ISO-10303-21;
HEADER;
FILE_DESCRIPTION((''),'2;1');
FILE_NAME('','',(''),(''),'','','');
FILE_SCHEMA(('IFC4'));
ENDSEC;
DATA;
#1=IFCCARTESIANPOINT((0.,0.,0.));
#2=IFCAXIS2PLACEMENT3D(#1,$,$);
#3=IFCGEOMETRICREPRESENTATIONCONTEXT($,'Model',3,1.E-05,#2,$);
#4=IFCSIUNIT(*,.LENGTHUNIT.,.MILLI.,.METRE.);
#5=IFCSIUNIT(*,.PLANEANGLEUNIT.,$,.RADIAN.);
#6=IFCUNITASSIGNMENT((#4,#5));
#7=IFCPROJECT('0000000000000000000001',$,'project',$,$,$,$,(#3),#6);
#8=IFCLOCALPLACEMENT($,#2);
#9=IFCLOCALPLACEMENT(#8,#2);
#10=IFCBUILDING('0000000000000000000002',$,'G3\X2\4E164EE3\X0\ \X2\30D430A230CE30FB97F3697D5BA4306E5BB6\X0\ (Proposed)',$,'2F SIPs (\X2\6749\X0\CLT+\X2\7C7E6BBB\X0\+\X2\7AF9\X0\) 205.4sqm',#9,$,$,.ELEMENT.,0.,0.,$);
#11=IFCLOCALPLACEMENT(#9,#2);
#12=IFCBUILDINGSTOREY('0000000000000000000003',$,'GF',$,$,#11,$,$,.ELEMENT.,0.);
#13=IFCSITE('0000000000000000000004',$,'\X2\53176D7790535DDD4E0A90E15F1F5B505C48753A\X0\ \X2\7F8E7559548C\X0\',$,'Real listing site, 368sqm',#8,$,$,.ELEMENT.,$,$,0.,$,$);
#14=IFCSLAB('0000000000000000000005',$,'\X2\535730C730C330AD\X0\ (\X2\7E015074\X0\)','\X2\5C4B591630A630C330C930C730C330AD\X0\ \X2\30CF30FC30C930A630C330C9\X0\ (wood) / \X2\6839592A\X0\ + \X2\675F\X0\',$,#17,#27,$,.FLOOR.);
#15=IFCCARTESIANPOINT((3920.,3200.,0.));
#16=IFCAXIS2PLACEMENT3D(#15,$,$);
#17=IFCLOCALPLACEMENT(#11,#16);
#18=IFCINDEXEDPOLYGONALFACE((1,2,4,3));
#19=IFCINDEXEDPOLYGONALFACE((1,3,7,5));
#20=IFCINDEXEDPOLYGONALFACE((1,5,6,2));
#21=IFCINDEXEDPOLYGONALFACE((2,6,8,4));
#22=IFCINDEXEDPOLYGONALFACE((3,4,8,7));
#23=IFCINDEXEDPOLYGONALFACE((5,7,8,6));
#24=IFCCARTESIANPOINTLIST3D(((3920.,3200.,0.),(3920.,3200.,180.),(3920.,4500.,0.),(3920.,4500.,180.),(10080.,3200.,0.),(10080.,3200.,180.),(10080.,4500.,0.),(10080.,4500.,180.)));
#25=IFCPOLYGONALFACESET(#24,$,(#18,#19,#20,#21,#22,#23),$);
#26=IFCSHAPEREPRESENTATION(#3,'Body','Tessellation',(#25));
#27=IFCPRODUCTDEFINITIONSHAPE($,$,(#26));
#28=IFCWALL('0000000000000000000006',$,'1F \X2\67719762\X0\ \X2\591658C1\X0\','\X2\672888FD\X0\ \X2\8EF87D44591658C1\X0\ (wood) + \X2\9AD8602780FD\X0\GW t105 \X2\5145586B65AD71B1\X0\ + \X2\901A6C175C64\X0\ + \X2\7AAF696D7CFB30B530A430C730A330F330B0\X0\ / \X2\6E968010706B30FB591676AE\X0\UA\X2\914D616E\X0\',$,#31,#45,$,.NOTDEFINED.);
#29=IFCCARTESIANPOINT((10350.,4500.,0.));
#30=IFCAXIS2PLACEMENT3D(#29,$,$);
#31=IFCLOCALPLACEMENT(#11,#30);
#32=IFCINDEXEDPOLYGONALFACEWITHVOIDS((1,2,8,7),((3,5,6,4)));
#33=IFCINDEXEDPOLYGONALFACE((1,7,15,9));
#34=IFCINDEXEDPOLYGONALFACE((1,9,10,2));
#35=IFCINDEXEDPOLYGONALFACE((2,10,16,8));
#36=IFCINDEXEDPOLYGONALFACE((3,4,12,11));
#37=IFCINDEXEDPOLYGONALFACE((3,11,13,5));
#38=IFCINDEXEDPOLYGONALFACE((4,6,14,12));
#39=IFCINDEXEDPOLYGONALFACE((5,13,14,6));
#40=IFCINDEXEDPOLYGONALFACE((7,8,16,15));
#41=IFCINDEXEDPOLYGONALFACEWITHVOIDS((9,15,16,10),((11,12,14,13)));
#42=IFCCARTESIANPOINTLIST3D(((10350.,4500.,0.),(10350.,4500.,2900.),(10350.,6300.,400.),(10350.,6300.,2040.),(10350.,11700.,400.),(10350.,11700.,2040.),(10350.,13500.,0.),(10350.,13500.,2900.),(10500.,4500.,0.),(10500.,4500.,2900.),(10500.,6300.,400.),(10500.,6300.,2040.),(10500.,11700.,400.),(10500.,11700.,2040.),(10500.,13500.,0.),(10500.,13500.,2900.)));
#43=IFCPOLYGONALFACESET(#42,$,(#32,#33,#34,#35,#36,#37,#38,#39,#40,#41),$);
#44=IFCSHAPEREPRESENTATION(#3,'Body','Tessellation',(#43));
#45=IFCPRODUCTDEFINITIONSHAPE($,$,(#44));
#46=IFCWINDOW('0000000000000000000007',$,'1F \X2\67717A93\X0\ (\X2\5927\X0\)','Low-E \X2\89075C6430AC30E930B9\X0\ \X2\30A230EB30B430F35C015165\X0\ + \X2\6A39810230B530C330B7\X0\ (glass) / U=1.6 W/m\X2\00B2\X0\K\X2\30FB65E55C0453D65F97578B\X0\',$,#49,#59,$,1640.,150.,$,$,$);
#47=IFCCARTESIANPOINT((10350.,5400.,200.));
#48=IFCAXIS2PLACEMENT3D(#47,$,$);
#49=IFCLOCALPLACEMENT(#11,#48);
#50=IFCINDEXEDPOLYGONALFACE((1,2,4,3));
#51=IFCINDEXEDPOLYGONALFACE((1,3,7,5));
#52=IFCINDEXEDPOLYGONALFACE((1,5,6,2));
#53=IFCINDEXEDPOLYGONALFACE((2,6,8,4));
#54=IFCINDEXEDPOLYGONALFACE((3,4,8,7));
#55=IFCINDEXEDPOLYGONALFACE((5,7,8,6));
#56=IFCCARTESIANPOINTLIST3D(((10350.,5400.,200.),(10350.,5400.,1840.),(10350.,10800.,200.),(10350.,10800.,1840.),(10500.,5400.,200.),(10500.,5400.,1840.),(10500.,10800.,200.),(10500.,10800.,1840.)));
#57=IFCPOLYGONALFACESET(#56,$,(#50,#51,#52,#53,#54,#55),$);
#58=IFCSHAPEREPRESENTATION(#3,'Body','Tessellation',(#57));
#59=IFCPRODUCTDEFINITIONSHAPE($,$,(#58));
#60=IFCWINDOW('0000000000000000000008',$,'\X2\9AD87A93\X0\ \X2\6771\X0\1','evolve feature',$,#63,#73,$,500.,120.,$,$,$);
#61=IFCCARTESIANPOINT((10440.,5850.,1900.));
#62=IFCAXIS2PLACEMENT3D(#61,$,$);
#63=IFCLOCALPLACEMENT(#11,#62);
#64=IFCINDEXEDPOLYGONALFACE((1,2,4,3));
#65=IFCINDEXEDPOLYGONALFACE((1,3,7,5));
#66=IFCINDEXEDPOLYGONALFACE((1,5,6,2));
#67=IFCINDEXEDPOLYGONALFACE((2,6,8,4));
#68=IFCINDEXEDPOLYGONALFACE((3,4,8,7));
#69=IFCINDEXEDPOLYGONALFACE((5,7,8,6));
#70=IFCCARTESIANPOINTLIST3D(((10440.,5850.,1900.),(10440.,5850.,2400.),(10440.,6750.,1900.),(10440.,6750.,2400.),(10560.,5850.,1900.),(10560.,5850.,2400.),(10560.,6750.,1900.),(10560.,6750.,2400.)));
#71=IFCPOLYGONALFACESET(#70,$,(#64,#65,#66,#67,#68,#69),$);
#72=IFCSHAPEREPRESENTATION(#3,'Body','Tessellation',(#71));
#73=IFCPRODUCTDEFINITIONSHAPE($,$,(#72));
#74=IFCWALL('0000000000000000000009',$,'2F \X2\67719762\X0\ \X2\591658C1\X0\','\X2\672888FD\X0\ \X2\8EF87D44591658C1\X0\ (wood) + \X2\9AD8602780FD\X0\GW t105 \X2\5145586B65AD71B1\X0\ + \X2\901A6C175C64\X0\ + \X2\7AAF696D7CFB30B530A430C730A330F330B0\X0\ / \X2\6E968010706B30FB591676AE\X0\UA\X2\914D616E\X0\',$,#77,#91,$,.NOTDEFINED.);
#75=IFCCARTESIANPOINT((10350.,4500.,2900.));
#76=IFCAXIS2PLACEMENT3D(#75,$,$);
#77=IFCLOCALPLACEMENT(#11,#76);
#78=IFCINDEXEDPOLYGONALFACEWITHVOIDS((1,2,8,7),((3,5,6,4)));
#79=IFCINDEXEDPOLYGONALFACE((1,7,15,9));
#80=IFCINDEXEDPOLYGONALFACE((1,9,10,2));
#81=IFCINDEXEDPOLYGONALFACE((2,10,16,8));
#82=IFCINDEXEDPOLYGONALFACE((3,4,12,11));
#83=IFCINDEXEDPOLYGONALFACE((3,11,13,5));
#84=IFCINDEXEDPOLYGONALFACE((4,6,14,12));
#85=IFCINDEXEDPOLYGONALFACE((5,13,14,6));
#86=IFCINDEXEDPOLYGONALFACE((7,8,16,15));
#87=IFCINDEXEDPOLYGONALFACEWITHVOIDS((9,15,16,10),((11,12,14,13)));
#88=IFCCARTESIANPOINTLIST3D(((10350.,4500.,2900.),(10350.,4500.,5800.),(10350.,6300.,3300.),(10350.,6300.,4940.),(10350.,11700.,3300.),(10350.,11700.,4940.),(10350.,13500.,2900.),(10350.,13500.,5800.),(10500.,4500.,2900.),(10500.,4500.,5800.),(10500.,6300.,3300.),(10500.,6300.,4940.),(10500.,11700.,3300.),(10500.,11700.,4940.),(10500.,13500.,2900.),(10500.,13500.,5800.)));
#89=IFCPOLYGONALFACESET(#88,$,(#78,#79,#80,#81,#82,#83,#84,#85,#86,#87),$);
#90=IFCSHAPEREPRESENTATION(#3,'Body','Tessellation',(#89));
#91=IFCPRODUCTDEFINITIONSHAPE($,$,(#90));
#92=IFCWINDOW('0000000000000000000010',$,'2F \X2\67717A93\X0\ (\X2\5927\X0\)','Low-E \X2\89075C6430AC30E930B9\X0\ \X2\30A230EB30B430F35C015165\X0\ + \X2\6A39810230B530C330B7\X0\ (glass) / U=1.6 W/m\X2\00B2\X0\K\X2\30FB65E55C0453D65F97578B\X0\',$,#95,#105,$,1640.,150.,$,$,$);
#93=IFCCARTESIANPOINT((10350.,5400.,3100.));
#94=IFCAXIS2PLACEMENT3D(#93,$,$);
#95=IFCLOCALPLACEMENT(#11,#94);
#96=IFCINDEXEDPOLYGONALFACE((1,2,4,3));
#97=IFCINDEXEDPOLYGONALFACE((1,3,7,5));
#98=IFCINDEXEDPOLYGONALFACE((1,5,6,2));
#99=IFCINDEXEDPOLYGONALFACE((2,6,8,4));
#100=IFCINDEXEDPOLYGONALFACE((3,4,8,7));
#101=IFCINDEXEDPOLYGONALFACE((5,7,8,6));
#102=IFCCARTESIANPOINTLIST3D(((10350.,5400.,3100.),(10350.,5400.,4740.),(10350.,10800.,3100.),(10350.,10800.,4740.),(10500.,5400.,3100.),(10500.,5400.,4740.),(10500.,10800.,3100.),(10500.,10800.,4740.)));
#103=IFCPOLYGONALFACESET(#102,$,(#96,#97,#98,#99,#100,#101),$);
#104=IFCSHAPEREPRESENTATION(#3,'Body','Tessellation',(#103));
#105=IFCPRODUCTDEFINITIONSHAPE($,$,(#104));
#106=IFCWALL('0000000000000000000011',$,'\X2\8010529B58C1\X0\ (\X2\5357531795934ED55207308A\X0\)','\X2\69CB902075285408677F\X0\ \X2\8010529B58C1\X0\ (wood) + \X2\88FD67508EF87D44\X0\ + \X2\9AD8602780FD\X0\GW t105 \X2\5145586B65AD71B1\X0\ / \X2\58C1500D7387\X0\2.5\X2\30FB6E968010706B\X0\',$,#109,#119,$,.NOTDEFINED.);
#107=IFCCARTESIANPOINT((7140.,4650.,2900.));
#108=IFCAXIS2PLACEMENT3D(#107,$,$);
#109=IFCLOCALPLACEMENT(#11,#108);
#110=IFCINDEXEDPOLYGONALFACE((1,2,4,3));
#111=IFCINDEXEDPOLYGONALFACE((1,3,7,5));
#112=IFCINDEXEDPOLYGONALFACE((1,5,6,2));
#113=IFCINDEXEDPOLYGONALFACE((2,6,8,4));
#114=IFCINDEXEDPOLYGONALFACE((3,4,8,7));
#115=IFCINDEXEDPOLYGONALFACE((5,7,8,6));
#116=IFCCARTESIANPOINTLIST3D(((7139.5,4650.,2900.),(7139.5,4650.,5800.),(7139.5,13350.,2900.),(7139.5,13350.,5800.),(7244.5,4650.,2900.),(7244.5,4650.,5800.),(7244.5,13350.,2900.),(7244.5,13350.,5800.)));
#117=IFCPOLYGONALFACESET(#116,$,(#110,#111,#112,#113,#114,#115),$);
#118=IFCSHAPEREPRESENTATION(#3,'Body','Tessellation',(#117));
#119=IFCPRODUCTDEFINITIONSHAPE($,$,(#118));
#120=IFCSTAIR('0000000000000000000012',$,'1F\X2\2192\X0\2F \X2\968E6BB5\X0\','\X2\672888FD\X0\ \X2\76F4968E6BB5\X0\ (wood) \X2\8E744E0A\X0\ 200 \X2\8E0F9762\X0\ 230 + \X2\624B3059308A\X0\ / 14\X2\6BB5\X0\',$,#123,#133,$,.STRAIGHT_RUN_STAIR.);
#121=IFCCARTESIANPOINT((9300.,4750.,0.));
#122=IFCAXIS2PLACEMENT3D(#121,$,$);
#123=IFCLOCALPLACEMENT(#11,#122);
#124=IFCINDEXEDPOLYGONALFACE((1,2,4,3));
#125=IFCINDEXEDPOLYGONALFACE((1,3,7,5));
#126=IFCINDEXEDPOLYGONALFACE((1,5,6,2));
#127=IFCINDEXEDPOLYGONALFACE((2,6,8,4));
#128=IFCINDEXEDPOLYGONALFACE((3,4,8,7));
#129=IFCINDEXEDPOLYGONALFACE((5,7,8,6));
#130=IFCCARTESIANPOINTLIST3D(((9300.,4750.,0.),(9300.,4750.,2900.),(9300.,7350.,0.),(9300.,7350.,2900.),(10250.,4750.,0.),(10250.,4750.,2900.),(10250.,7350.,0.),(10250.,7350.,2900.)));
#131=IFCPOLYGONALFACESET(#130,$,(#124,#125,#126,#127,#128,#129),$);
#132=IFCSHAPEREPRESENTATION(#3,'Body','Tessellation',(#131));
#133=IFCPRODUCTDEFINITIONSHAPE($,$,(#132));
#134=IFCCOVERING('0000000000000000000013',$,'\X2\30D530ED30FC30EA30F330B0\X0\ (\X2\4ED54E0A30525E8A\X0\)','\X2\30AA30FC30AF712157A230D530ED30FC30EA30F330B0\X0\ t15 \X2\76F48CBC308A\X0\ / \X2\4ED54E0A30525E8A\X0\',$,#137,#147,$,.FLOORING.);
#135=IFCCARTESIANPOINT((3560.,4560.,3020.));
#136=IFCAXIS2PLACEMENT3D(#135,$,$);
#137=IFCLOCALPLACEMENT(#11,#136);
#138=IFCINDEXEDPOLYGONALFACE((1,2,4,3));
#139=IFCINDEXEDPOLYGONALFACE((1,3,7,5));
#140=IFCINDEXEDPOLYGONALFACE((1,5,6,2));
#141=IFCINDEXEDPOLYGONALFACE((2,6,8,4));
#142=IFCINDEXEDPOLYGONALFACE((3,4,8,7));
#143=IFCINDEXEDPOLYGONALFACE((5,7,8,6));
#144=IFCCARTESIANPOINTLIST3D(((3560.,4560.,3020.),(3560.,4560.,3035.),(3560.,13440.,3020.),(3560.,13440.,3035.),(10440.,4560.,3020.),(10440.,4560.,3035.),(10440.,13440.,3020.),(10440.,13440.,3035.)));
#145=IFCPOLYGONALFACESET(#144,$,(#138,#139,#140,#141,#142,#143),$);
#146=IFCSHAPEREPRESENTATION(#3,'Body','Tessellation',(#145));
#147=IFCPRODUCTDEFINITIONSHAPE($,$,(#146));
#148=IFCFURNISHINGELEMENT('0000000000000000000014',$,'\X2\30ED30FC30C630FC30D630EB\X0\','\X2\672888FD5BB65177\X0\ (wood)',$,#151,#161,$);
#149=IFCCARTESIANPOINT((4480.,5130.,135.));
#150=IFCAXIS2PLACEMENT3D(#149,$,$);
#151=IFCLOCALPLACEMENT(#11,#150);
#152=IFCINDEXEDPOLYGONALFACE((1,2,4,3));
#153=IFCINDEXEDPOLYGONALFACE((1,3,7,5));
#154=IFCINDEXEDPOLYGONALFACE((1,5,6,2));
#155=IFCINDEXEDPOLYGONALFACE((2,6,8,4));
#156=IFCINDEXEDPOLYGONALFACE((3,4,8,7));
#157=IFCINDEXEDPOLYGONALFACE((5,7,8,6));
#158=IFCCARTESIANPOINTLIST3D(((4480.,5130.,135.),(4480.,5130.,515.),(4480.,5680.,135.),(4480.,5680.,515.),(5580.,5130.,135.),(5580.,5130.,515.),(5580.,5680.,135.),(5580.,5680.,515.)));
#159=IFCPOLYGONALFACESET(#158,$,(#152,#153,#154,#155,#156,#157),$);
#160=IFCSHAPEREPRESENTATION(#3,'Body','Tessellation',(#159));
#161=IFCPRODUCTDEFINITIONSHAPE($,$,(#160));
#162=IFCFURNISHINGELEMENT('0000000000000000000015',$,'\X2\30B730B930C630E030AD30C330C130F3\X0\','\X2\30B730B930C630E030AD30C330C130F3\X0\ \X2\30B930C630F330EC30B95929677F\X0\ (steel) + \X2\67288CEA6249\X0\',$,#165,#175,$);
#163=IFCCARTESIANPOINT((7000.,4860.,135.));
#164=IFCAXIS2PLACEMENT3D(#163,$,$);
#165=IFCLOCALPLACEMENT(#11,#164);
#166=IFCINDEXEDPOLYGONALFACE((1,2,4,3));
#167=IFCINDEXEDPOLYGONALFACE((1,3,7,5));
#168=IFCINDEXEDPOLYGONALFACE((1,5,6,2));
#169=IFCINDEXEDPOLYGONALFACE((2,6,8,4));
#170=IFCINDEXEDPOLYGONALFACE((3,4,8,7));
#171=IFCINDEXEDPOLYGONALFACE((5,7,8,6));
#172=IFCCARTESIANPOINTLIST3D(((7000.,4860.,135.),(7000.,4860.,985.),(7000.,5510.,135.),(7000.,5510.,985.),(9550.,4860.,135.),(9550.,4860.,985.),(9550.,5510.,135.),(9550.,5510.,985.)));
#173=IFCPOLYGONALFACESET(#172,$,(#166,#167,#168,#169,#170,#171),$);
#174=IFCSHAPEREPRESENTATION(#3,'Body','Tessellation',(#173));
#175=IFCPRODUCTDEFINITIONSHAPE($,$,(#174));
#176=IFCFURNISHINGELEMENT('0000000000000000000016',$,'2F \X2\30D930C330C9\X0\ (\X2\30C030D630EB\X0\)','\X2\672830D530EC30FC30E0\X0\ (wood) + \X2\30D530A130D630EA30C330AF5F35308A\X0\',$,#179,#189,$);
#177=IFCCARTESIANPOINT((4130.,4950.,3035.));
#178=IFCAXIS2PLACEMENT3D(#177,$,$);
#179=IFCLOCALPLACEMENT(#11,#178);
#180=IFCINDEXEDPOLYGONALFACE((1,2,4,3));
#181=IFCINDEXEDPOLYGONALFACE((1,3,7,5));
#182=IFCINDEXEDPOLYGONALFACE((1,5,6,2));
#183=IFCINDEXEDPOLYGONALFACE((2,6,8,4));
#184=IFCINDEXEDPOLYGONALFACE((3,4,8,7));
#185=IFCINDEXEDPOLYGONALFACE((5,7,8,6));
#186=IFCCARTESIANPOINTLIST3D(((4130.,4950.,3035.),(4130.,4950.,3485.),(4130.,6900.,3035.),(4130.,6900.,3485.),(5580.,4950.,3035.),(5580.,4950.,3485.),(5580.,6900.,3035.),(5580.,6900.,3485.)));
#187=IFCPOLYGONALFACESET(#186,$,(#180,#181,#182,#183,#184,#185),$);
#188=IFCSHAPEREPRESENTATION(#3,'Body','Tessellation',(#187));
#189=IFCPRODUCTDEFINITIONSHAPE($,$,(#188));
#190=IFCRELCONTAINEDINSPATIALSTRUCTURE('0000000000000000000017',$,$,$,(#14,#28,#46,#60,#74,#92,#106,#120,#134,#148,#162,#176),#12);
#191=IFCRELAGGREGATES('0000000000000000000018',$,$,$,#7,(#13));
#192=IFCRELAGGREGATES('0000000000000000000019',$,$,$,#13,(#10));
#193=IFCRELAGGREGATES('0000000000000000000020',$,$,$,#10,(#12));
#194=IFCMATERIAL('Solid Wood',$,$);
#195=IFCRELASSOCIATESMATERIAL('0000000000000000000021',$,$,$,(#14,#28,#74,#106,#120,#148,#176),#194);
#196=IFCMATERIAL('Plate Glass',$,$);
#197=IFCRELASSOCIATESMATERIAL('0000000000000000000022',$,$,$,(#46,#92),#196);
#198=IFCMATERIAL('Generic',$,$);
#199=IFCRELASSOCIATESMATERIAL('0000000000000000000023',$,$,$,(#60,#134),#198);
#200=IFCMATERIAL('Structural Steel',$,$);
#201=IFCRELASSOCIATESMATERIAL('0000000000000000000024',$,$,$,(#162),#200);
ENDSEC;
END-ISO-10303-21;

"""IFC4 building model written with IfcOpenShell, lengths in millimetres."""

from ifc_helpers import new_model, si_unit, frame, frame_2d, origin, place, context, project, spatial, rectangle, extrude, material, element, fill, save


model = new_model("IFC4")

# Units and contexts
model_context = context("Model", 3, precision=1e-05, world=origin())
ifc_project = project(units=[si_unit("LENGTHUNIT", "METRE", prefix="MILLI"), si_unit("PLANEANGLEUNIT", "RADIAN")], contexts=[model_context])

# Site, building, storey
site_placement = place(None, origin())
site = spatial("IfcSite", under=ifc_project, at=site_placement, Name="北海道川上郡弟子屈町 美留和", ObjectType="Real listing site, 368sqm", CompositionType="ELEMENT", RefElevation=0.0)
building_placement = place(site_placement, origin())
building = spatial("IfcBuilding", under=site, at=building_placement, Name="G3世代 ピアノ・音楽室の家 (Proposed)", ObjectType="2F SIPs (杉CLT+籾殻+竹) 205.4sqm", CompositionType="ELEMENT", ElevationOfRefHeight=0.0, ElevationOfTerrain=0.0)
storey_placement = place(building_placement, origin())
storey = spatial("IfcBuildingStorey", under=building, at=storey_placement, Name="GF", CompositionType="ELEMENT", Elevation=0.0)

# Slab
ifc_material_1 = material(Name="Solid Wood")
slab_placement = place(storey_placement, frame((3920.0, 3200.0, 0.0)))
element("IfcSlab", 1, at=slab_placement, inside=storey, material=ifc_material_1, Name="南デッキ (縁側)", Description="屋外ウッドデッキ ハードウッド (wood) / 根太 + 束", PredefinedType="FLOOR", context=model_context, shape_type="SweptSolid", body=[
    extrude(rectangle(XDim=6160.0, YDim=1300.0, at=frame_2d((3080.0, 650.0))), frame((3920.0, 3200.0, 0.0)), (0.0, 0.0, 1.0), 180.0),
])

# Wall, openings, windows
wall_1_placement = place(storey_placement, frame((10350.0, 4500.0, 0.0)))
wall_1 = element("IfcWall", 2, at=wall_1_placement, inside=storey, material=ifc_material_1, Name="1F 東面 外壁", Description="木製 軸組外壁 (wood) + 高性能GW t105 充填断熱 + 通気層 + 窯業系サイディング / 準耐火・外皮UA配慮", PredefinedType="NOTDEFINED", context=model_context, shape_type="SweptSolid", body=[
    extrude(rectangle(XDim=150.0, YDim=9000.0, at=frame_2d((75.0, 4500.0))), frame((10350.0, 4500.0, 0.0)), (0.0, 0.0, 1.0), 2900.0),
])
opening_1_placement = place(storey_placement, frame((10350.0, 5400.0, 200.0)))
opening_1 = element("IfcOpeningElement", 3, at=opening_1_placement, cuts=wall_1, PredefinedType="NOTDEFINED", context=model_context, shape_type="SweptSolid", body=[
    extrude(rectangle(XDim=150.0, YDim=5400.0, at=frame_2d((75.0, 2700.0))), frame((10350.0, 5400.0, 200.0)), (0.0, 0.0, 1.0), 1640.0),
])
opening_2_placement = place(storey_placement, frame((10440.0, 5850.0, 1900.0)))
opening_2 = element("IfcOpeningElement", 4, at=opening_2_placement, cuts=wall_1, PredefinedType="NOTDEFINED", context=model_context, shape_type="SweptSolid", body=[
    extrude(rectangle(XDim=120.0, YDim=900.0, at=frame_2d((60.0, 450.0))), frame((10440.0, 5850.0, 1900.0)), (0.0, 0.0, 1.0), 500.0),
])
ifc_material_2 = material(Name="Plate Glass")
window_1_placement = place(storey_placement, frame((10350.0, 5400.0, 200.0)))
window_1 = element("IfcWindow", 5, at=window_1_placement, inside=storey, material=ifc_material_2, Name="1F 東窓 (大)", Description="Low-E 複層ガラス アルゴン封入 + 樹脂サッシ (glass) / U=1.6 W/m²K・日射取得型", OverallHeight=1640.0, OverallWidth=150.0, context=model_context, shape_type="SweptSolid", body=[
    extrude(rectangle(XDim=150.0, YDim=5400.0, at=frame_2d((75.0, 2700.0))), frame((10350.0, 5400.0, 200.0)), (0.0, 0.0, 1.0), 1640.0),
])
fill(opening_1, window_1)
ifc_material_3 = material(Name="Generic")
window_2_placement = place(storey_placement, frame((10440.0, 5850.0, 1900.0)))
window_2 = element("IfcWindow", 6, at=window_2_placement, inside=storey, material=ifc_material_3, Name="高窓 東1", Description="evolve feature", OverallHeight=500.0, OverallWidth=120.0, context=model_context, shape_type="SweptSolid", body=[
    extrude(rectangle(XDim=120.0, YDim=900.0, at=frame_2d((60.0, 450.0))), frame((10440.0, 5850.0, 1900.0)), (0.0, 0.0, 1.0), 500.0),
])
fill(opening_2, window_2)

# Wall, opening, window
wall_2_placement = place(storey_placement, frame((10350.0, 4500.0, 2900.0)))
wall_2 = element("IfcWall", 7, at=wall_2_placement, inside=storey, material=ifc_material_1, Name="2F 東面 外壁", Description="木製 軸組外壁 (wood) + 高性能GW t105 充填断熱 + 通気層 + 窯業系サイディング / 準耐火・外皮UA配慮", PredefinedType="NOTDEFINED", context=model_context, shape_type="SweptSolid", body=[
    extrude(rectangle(XDim=150.0, YDim=9000.0, at=frame_2d((75.0, 4500.0))), frame((10350.0, 4500.0, 2900.0)), (0.0, 0.0, 1.0), 2900.0),
])
opening_3_placement = place(storey_placement, frame((10350.0, 5400.0, 3100.0)))
opening_3 = element("IfcOpeningElement", 8, at=opening_3_placement, cuts=wall_2, PredefinedType="NOTDEFINED", context=model_context, shape_type="SweptSolid", body=[
    extrude(rectangle(XDim=150.0, YDim=5400.0, at=frame_2d((75.0, 2700.0))), frame((10350.0, 5400.0, 3100.0)), (0.0, 0.0, 1.0), 1640.0),
])
window_3_placement = place(storey_placement, frame((10350.0, 5400.0, 3100.0)))
window_3 = element("IfcWindow", 9, at=window_3_placement, inside=storey, material=ifc_material_2, Name="2F 東窓 (大)", Description="Low-E 複層ガラス アルゴン封入 + 樹脂サッシ (glass) / U=1.6 W/m²K・日射取得型", OverallHeight=1640.0, OverallWidth=150.0, context=model_context, shape_type="SweptSolid", body=[
    extrude(rectangle(XDim=150.0, YDim=5400.0, at=frame_2d((75.0, 2700.0))), frame((10350.0, 5400.0, 3100.0)), (0.0, 0.0, 1.0), 1640.0),
])
fill(opening_3, window_3)

# Wall
wall_3_placement = place(storey_placement, frame((7140.0, 4650.0, 2900.0)))
element("IfcWall", 10, at=wall_3_placement, inside=storey, material=ifc_material_1, Name="耐力壁 (南北間仕切り)", Description="構造用合板 耐力壁 (wood) + 製材軸組 + 高性能GW t105 充填断熱 / 壁倍率2.5・準耐火", PredefinedType="NOTDEFINED", context=model_context, shape_type="SweptSolid", body=[
    extrude(rectangle(XDim=105.0, YDim=8700.0, at=frame_2d((52.0, 4350.0))), frame((7140.0, 4650.0, 2900.0)), (0.0, 0.0, 1.0), 2900.0),
])

# Stair
stair_placement = place(storey_placement, frame((9300.0, 4750.0, 0.0)))
element("IfcStair", 11, at=stair_placement, inside=storey, material=ifc_material_1, Name="1F→2F 階段", Description="木製 直階段 (wood) 蹴上 200 踏面 230 + 手すり / 14段", PredefinedType="STRAIGHT_RUN_STAIR", context=model_context, shape_type="SweptSolid", body=[
    extrude(rectangle(XDim=950.0, YDim=2600.0, at=frame_2d((475.0, 1300.0))), frame((9300.0, 4750.0, 0.0)), (0.0, 0.0, 1.0), 2900.0),
])

# Covering
covering_placement = place(storey_placement, frame((3560.0, 4560.0, 3020.0)))
element("IfcCovering", 12, at=covering_placement, inside=storey, material=ifc_material_3, Name="フローリング (仕上げ床)", Description="オーク無垢フローリング t15 直貼り / 仕上げ床", PredefinedType="FLOORING", context=model_context, shape_type="SweptSolid", body=[
    extrude(rectangle(XDim=6880.0, YDim=8880.0, at=frame_2d((3440.0, 4440.0))), frame((3560.0, 4560.0, 3020.0)), (0.0, 0.0, 1.0), 15.0),
])

# Furnishing elements
furnishing_1_placement = place(storey_placement, frame((4480.0, 5130.0, 135.0)))
element("IfcFurnishingElement", 13, at=furnishing_1_placement, inside=storey, material=ifc_material_1, Name="ローテーブル", Description="木製家具 (wood)", context=model_context, shape_type="SweptSolid", body=[
    extrude(rectangle(XDim=1100.0, YDim=550.0, at=frame_2d((550.0, 275.0))), frame((4480.0, 5130.0, 135.0)), (0.0, 0.0, 1.0), 380.0),
])
ifc_material_4 = material(Name="Structural Steel")
furnishing_2_placement = place(storey_placement, frame((7000.0, 4860.0, 135.0)))
element("IfcFurnishingElement", 14, at=furnishing_2_placement, inside=storey, material=ifc_material_4, Name="システムキッチン", Description="システムキッチン ステンレス天板 (steel) + 木質扉", context=model_context, shape_type="SweptSolid", body=[
    extrude(rectangle(XDim=2550.0, YDim=650.0, at=frame_2d((1275.0, 325.0))), frame((7000.0, 4860.0, 135.0)), (0.0, 0.0, 1.0), 850.0),
])
furnishing_3_placement = place(storey_placement, frame((4130.0, 4950.0, 3035.0)))
element("IfcFurnishingElement", 15, at=furnishing_3_placement, inside=storey, material=ifc_material_1, Name="2F ベッド (ダブル)", Description="木フレーム (wood) + ファブリック張り", context=model_context, shape_type="SweptSolid", body=[
    extrude(rectangle(XDim=1450.0, YDim=1950.0, at=frame_2d((725.0, 975.0))), frame((4130.0, 4950.0, 3035.0)), (0.0, 0.0, 1.0), 450.0),
])

save(model, "model.ifc")
